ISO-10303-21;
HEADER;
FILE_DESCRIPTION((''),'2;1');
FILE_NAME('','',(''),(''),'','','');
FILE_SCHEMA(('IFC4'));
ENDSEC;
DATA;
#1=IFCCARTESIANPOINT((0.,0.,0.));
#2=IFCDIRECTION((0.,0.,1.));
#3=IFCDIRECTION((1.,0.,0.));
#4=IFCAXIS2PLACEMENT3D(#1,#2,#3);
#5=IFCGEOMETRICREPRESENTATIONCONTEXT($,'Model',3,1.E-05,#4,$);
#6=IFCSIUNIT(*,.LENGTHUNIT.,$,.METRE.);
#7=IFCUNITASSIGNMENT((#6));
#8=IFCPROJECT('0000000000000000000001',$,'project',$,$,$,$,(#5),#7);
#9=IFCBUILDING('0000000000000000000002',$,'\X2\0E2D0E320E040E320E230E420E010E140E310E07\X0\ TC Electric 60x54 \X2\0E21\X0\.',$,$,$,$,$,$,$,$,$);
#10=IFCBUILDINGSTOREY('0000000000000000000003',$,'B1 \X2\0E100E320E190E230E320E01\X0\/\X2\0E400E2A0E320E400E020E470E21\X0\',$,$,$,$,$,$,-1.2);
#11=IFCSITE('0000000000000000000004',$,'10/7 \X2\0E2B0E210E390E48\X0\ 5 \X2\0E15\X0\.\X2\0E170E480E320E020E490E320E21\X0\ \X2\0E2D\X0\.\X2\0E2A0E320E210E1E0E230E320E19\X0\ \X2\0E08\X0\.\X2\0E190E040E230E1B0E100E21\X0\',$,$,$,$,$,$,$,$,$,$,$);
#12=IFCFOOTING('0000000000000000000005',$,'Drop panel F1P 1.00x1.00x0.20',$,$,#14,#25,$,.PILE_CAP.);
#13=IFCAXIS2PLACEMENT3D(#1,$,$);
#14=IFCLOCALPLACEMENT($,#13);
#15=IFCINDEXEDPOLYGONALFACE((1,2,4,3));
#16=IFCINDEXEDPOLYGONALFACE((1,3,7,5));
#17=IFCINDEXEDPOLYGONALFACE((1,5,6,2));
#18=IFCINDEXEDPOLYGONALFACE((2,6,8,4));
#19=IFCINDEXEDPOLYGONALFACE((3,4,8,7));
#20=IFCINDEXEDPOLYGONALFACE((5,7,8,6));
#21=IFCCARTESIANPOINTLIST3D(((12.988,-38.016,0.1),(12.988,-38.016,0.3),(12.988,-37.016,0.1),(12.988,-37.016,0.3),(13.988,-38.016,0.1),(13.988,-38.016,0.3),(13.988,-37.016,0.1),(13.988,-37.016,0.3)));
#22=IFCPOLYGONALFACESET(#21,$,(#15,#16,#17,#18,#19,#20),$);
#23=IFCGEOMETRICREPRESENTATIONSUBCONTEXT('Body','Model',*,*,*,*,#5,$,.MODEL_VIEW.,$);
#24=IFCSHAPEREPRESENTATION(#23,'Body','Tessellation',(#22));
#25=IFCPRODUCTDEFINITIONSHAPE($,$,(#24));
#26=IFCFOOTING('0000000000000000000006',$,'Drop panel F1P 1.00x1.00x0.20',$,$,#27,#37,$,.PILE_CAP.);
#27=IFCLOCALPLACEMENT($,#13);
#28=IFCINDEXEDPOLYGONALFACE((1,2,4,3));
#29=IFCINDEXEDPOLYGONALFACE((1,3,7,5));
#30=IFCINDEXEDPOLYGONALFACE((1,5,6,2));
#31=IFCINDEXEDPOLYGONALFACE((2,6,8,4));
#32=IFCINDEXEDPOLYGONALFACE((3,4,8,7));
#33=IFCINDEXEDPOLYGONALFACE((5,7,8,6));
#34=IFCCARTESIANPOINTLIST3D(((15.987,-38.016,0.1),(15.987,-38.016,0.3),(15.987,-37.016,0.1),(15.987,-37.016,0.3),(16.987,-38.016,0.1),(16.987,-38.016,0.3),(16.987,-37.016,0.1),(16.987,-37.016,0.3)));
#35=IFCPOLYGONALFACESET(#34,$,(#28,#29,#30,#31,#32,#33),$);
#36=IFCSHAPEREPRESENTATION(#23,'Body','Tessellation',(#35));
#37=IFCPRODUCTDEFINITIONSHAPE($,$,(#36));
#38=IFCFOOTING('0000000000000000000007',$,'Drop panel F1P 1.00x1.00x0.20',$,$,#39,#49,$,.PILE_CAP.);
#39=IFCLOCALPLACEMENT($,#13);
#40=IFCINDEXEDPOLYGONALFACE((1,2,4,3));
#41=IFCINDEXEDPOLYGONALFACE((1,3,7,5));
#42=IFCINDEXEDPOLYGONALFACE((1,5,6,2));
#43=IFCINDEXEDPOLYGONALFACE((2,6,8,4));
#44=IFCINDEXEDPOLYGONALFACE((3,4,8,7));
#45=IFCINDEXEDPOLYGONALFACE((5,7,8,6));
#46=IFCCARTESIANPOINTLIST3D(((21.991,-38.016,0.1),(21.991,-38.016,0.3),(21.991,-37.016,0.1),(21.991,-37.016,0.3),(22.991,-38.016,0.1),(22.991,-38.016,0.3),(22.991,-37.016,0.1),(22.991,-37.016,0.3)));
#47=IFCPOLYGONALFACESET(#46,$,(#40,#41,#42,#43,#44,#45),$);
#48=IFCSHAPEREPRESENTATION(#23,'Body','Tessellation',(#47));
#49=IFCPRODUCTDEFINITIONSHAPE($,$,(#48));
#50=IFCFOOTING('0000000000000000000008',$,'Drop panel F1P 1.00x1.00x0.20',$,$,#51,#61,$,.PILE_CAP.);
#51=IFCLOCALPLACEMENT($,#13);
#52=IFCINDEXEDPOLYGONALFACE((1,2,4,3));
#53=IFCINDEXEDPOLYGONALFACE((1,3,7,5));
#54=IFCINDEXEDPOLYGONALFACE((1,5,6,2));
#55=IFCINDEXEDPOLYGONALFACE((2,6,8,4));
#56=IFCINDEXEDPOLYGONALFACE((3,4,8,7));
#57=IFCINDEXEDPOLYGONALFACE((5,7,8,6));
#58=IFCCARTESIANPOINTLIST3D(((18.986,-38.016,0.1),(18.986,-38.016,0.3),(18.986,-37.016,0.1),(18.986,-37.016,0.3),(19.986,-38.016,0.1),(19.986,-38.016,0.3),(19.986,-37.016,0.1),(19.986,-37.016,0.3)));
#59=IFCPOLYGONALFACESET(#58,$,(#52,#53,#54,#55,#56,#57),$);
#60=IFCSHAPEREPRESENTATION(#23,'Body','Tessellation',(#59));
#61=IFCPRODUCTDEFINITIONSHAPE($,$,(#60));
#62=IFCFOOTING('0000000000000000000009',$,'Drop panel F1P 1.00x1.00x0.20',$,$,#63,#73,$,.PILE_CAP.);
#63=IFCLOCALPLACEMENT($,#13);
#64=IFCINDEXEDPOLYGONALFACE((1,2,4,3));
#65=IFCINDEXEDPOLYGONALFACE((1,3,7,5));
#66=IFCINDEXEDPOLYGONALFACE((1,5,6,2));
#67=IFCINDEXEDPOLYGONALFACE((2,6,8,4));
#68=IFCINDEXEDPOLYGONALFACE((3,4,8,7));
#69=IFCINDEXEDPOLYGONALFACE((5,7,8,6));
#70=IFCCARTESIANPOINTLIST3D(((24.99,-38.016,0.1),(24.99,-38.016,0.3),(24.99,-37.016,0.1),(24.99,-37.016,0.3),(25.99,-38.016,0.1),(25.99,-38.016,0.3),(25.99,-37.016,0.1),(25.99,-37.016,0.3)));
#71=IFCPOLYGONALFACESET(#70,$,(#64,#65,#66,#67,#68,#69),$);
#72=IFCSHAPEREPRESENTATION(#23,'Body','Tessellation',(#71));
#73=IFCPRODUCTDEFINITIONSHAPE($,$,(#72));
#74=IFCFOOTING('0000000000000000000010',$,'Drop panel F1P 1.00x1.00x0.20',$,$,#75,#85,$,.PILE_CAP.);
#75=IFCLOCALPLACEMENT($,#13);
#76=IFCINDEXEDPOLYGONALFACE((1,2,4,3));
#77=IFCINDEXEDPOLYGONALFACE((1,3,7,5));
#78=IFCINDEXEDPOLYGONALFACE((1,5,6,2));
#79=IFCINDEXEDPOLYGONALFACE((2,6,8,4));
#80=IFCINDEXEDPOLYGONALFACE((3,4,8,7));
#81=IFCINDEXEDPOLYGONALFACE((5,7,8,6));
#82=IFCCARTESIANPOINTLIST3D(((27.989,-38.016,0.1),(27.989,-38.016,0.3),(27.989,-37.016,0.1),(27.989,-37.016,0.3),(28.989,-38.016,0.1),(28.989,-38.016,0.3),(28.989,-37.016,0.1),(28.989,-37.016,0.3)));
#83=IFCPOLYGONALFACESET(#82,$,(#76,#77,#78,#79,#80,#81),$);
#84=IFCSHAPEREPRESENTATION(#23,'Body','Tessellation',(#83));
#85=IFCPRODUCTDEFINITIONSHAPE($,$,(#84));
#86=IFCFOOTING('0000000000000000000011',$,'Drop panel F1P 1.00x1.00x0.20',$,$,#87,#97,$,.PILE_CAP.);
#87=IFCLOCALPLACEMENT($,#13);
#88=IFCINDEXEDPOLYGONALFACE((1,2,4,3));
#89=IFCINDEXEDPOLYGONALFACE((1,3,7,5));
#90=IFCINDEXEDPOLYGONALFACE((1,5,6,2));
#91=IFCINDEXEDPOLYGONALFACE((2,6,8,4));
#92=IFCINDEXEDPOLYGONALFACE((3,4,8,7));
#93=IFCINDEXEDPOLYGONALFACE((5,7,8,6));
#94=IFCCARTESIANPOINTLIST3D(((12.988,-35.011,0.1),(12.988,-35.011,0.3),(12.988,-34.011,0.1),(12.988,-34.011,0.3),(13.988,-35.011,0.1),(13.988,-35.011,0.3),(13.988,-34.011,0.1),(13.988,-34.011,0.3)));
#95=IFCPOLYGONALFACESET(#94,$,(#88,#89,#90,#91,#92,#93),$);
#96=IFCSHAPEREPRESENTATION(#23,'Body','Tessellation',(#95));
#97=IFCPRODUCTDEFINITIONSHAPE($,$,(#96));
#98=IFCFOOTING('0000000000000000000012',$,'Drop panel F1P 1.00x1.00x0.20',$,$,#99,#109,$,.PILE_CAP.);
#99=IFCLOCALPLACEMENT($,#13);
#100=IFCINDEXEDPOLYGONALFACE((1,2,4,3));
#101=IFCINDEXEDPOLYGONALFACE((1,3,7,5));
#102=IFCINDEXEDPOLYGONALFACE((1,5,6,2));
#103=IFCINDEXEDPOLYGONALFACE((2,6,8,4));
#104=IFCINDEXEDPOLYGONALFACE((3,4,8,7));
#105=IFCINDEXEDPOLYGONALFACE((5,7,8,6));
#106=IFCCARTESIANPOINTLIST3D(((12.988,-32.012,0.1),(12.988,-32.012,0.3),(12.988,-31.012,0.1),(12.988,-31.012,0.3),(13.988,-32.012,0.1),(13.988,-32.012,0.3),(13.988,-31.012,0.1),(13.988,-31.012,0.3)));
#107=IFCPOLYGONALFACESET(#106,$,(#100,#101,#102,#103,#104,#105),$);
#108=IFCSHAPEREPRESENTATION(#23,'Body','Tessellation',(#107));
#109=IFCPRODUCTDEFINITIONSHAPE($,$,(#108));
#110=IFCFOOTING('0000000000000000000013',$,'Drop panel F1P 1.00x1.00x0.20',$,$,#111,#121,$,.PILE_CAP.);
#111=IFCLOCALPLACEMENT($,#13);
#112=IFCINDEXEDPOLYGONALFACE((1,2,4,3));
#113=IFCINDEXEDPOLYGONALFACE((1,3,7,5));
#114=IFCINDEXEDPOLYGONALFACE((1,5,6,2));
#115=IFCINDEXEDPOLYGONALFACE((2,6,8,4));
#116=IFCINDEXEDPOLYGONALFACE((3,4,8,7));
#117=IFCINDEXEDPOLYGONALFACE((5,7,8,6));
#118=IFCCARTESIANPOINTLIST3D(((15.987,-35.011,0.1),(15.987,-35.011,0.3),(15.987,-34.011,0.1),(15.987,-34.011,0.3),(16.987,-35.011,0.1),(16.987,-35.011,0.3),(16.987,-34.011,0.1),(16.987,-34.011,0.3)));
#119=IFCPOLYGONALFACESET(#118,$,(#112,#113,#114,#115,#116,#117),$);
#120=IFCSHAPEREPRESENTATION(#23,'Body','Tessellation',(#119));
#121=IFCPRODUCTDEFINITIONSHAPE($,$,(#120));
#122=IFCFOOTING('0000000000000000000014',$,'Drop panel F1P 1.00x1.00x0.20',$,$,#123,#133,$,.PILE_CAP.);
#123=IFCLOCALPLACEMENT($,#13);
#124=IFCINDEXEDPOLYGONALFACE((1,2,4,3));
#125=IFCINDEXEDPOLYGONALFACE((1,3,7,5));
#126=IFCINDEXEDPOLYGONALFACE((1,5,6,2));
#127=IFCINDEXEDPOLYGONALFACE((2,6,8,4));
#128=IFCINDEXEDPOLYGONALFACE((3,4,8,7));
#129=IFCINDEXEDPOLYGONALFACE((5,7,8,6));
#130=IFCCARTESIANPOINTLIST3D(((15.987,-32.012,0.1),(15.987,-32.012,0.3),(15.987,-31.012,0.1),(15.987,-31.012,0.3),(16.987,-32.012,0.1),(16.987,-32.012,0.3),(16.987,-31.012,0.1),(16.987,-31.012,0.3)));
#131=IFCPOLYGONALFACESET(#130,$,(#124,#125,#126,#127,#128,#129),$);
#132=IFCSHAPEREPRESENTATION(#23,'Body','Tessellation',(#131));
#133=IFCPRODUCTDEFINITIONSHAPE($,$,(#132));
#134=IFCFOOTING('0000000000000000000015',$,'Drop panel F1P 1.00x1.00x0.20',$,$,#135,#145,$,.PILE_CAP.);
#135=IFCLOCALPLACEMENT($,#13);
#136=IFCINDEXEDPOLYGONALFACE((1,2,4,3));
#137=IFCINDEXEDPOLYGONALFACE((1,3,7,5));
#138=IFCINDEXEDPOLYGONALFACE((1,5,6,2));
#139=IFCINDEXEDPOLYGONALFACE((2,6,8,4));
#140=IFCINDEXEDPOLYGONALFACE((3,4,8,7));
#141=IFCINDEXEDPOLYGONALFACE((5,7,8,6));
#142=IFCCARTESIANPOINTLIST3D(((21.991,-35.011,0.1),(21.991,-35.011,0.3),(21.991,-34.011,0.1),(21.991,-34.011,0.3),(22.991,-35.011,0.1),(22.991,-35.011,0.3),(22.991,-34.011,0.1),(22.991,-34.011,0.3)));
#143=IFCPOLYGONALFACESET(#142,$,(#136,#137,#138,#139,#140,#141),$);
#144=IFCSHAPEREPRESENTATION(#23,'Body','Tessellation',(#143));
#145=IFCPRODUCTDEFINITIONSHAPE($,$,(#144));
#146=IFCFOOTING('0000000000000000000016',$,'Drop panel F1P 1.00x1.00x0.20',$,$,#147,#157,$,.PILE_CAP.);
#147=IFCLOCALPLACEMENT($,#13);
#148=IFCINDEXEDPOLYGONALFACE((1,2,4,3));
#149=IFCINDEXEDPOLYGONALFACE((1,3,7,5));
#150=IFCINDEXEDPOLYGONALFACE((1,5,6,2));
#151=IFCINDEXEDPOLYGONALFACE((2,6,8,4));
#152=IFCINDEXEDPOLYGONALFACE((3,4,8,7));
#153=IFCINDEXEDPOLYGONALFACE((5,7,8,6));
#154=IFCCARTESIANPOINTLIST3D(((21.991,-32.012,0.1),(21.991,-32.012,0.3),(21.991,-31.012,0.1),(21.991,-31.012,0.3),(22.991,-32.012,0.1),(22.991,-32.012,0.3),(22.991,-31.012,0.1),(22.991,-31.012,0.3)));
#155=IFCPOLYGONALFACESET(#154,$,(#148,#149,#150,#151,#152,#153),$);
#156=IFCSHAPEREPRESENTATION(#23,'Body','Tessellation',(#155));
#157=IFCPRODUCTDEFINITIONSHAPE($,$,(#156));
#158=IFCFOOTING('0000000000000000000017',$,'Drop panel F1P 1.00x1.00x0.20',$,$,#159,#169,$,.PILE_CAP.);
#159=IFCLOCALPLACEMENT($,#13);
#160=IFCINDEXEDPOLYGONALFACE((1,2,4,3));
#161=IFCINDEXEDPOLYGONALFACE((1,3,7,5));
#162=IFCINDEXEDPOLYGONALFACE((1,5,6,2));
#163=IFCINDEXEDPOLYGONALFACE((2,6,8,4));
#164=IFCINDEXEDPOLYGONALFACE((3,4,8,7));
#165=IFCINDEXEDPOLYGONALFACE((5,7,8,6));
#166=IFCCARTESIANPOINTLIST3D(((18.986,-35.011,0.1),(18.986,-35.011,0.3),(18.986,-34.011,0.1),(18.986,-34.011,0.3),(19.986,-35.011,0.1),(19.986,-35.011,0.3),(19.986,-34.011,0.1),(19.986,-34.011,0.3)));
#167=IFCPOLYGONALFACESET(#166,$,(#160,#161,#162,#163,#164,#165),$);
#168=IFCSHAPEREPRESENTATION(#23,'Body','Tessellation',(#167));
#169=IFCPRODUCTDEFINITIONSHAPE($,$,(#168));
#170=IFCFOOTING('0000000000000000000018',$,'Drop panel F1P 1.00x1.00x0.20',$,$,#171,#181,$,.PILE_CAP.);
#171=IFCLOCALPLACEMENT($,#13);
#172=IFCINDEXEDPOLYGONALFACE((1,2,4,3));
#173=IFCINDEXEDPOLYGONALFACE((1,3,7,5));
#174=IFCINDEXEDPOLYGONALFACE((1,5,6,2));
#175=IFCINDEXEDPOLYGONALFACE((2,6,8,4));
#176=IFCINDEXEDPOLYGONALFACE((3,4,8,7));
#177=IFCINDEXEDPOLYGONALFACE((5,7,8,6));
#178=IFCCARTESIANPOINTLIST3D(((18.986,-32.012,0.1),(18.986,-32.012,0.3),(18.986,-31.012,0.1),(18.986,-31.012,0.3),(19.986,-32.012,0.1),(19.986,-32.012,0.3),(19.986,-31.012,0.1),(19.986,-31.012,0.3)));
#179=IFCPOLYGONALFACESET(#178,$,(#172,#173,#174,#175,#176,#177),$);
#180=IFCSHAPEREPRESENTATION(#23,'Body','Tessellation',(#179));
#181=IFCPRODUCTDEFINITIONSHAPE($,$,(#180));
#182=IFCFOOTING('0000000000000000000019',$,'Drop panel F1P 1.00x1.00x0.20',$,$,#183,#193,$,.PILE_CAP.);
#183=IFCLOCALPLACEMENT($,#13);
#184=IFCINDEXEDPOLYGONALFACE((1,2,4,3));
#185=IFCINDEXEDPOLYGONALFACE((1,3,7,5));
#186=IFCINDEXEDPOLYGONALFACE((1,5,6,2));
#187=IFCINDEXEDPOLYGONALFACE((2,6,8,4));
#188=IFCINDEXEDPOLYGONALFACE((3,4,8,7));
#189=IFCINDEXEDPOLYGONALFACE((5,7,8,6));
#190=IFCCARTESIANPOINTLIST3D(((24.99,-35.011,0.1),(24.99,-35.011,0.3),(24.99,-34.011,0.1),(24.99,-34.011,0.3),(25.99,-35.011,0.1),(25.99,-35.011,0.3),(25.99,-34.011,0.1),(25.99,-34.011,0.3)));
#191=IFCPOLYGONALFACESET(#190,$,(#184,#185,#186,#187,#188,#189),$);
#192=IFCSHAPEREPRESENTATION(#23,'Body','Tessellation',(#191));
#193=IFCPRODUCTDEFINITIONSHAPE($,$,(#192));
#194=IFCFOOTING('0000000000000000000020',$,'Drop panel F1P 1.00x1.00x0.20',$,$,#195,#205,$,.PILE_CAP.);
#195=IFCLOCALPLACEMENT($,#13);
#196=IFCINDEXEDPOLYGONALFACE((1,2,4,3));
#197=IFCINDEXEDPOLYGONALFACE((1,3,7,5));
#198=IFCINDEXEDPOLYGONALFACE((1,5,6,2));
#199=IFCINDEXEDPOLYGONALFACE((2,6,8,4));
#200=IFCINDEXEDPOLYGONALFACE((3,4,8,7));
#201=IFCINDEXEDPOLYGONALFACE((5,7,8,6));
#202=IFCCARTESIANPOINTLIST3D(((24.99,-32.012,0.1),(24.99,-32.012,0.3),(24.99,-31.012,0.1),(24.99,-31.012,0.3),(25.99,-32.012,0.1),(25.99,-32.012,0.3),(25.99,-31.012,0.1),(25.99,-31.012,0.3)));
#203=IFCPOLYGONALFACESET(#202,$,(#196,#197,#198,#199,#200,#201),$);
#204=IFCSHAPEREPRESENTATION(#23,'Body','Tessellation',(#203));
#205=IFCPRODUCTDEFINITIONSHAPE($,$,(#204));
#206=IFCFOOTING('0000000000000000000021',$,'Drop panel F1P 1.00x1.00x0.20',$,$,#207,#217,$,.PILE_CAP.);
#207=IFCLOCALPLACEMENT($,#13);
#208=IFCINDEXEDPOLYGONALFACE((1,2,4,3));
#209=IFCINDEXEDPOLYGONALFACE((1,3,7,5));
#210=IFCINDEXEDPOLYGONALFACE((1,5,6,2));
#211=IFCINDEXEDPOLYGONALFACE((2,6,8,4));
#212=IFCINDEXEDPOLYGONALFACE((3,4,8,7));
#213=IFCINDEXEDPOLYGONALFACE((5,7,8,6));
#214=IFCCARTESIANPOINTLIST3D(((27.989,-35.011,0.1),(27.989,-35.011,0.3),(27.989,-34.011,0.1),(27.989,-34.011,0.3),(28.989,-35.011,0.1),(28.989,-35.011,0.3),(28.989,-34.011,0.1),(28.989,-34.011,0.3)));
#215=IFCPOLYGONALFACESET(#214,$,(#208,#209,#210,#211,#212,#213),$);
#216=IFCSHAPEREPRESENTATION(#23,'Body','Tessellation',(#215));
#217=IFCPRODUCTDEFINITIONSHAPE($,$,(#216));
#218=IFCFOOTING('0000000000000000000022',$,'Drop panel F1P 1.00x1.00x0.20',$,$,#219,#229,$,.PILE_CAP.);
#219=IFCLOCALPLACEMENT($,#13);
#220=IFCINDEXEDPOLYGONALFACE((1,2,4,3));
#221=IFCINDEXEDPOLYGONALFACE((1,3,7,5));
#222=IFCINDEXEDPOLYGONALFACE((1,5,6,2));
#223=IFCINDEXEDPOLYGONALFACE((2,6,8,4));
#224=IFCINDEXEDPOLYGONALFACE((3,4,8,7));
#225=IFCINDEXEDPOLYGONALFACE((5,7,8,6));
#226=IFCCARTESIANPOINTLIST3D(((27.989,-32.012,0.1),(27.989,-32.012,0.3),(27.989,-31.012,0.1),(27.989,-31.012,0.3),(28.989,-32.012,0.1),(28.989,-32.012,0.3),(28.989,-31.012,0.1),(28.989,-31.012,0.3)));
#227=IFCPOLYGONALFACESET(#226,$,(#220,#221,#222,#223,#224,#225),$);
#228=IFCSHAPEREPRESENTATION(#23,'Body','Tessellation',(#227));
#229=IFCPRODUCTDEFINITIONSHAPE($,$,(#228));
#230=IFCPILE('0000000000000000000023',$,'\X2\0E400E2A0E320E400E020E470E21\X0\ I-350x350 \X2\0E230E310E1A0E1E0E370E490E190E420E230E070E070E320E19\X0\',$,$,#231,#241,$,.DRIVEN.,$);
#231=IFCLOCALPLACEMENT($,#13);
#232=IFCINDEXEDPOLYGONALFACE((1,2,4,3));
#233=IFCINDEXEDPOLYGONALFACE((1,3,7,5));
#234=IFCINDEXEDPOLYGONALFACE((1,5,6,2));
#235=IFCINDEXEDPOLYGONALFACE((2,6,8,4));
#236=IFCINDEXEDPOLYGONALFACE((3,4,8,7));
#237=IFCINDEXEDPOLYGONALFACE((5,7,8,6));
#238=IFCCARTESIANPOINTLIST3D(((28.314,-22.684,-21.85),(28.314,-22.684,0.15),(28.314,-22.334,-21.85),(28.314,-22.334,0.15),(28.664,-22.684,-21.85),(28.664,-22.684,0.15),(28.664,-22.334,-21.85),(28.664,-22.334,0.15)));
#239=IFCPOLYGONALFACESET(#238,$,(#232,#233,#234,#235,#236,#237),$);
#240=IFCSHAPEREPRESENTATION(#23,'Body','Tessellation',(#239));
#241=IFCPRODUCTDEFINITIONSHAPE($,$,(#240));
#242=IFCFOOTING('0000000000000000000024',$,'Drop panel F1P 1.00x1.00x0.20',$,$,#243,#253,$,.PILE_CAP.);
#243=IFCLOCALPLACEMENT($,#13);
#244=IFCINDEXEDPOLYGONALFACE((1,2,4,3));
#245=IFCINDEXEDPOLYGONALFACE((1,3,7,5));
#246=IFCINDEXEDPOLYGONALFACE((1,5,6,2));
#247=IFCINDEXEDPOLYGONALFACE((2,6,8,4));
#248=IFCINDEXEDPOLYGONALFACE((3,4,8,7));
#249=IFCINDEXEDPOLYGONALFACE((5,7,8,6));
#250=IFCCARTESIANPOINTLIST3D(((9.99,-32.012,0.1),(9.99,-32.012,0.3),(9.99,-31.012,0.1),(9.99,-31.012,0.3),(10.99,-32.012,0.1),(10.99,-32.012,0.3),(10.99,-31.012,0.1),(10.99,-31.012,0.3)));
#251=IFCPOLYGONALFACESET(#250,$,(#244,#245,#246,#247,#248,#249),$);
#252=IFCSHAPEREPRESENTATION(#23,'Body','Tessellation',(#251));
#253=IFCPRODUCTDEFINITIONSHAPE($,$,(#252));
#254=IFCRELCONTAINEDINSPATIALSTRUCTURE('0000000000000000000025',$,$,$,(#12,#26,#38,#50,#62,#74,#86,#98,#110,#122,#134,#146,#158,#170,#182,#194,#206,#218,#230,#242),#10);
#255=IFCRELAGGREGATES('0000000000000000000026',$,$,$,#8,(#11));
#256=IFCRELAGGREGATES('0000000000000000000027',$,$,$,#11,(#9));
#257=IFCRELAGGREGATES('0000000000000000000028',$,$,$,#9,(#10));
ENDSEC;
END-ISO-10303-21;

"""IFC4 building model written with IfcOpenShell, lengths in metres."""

from ifc_helpers import new_model, si_unit, frame, origin, origin_with_axes, origin_2d, place, context, subcontext, project, spatial, rectangle, extrude, element, save


model = new_model("IFC4")

# Units and contexts
model_context = context("Model", 3, precision=1e-05, world=origin_with_axes())
body_context = subcontext(model_context, "Body", "Model", "MODEL_VIEW")
ifc_project = project(units=[si_unit("LENGTHUNIT", "METRE")], contexts=[model_context])

# Site, building, storey
site = spatial("IfcSite", under=ifc_project, Name="10/7 หมู่ 5 ต.ท่าข้าม อ.สามพราน จ.นครปฐม")
building = spatial("IfcBuilding", under=site, Name="อาคารโกดัง TC Electric 60x54 ม.")
storey = spatial("IfcBuildingStorey", under=building, Name="B1 ฐานราก/เสาเข็ม", Elevation=-1.2)

# Footings
for number, where, z_axis, x_axis, name in (
    (1, (13.488, -37.516, 0.1), (0.0, 0.0, 1.0), (1.0, 0.0, 0.0), "Drop panel F1P 1.00x1.00x0.20"),
    (2, (16.487, -37.516, 0.1), (0.0, 0.0, 1.0), (1.0, 0.0, 0.0), "Drop panel F1P 1.00x1.00x0.20"),
    (3, (22.491, -37.516, 0.1), (0.0, 0.0, 1.0), (1.0, 0.0, 0.0), "Drop panel F1P 1.00x1.00x0.20"),
    (4, (19.486, -37.516, 0.1), (0.0, 0.0, 1.0), (1.0, 0.0, 0.0), "Drop panel F1P 1.00x1.00x0.20"),
    (5, (25.49, -37.516, 0.1), (0.0, 0.0, 1.0), (1.0, 0.0, 0.0), "Drop panel F1P 1.00x1.00x0.20"),
    (6, (28.489, -37.516, 0.1), (0.0, 0.0, 1.0), (1.0, 0.0, 0.0), "Drop panel F1P 1.00x1.00x0.20"),
    (7, (13.488, -34.511, 0.1), (0.0, 0.0, 1.0), (1.0, 0.0, 0.0), "Drop panel F1P 1.00x1.00x0.20"),
    (8, (13.488, -31.512, 0.1), (0.0, 0.0, 1.0), (1.0, 0.0, 0.0), "Drop panel F1P 1.00x1.00x0.20"),
    (9, (16.487, -34.511, 0.1), (0.0, 0.0, 1.0), (1.0, 0.0, 0.0), "Drop panel F1P 1.00x1.00x0.20"),
    (10, (16.487, -31.512, 0.1), (0.0, 0.0, 1.0), (1.0, 0.0, 0.0), "Drop panel F1P 1.00x1.00x0.20"),
    (11, (22.491, -34.511, 0.1), (0.0, 0.0, 1.0), (1.0, 0.0, 0.0), "Drop panel F1P 1.00x1.00x0.20"),
    (12, (22.491, -31.512, 0.1), (0.0, 0.0, 1.0), (1.0, 0.0, 0.0), "Drop panel F1P 1.00x1.00x0.20"),
    (13, (19.486, -34.511, 0.1), (0.0, 0.0, 1.0), (1.0, 0.0, 0.0), "Drop panel F1P 1.00x1.00x0.20"),
    (14, (19.486, -31.512, 0.1), (0.0, 0.0, 1.0), (1.0, 0.0, 0.0), "Drop panel F1P 1.00x1.00x0.20"),
    (15, (25.49, -34.511, 0.1), (0.0, 0.0, 1.0), (1.0, 0.0, 0.0), "Drop panel F1P 1.00x1.00x0.20"),
    (16, (25.49, -31.512, 0.1), (0.0, 0.0, 1.0), (1.0, 0.0, 0.0), "Drop panel F1P 1.00x1.00x0.20"),
    (17, (28.489, -34.511, 0.1), (0.0, 0.0, 1.0), (1.0, 0.0, 0.0), "Drop panel F1P 1.00x1.00x0.20"),
    (18, (28.489, -31.512, 0.1), (0.0, 0.0, 1.0), (1.0, 0.0, 0.0), "Drop panel F1P 1.00x1.00x0.20"),
):
    element("IfcFooting", number, at=place(None, frame(where, z_axis=z_axis, x_axis=x_axis)), inside=storey, Name=name, PredefinedType="PILE_CAP", context=body_context, shape_type="SweptSolid", body=[
        extrude(rectangle(XDim=1.0, YDim=1.0, at=origin_2d()), origin(), (0.0, 0.0, 1.0), 0.2),
    ])

# Pile
pile_placement = place(None, frame((28.489, -22.509, -21.85), z_axis=(0.0, 0.0, 1.0), x_axis=(1.0, 0.0, 0.0)))
element("IfcPile", 19, at=pile_placement, inside=storey, Name="เสาเข็ม I-350x350 รับพื้นโรงงาน", PredefinedType="DRIVEN", context=body_context, shape_type="SweptSolid", body=[
    extrude(rectangle(XDim=0.35, YDim=0.35, at=origin_2d()), origin(), (0.0, 0.0, 1.0), 22.0),
])

# Footing
footing_placement = place(None, frame((10.49, -31.512, 0.1), z_axis=(0.0, 0.0, 1.0), x_axis=(1.0, 0.0, 0.0)))
element("IfcFooting", 20, at=footing_placement, inside=storey, Name="Drop panel F1P 1.00x1.00x0.20", PredefinedType="PILE_CAP", context=body_context, shape_type="SweptSolid", body=[
    extrude(rectangle(XDim=1.0, YDim=1.0, at=origin_2d()), origin(), (0.0, 0.0, 1.0), 0.2),
])

save(model, "model.ifc")
